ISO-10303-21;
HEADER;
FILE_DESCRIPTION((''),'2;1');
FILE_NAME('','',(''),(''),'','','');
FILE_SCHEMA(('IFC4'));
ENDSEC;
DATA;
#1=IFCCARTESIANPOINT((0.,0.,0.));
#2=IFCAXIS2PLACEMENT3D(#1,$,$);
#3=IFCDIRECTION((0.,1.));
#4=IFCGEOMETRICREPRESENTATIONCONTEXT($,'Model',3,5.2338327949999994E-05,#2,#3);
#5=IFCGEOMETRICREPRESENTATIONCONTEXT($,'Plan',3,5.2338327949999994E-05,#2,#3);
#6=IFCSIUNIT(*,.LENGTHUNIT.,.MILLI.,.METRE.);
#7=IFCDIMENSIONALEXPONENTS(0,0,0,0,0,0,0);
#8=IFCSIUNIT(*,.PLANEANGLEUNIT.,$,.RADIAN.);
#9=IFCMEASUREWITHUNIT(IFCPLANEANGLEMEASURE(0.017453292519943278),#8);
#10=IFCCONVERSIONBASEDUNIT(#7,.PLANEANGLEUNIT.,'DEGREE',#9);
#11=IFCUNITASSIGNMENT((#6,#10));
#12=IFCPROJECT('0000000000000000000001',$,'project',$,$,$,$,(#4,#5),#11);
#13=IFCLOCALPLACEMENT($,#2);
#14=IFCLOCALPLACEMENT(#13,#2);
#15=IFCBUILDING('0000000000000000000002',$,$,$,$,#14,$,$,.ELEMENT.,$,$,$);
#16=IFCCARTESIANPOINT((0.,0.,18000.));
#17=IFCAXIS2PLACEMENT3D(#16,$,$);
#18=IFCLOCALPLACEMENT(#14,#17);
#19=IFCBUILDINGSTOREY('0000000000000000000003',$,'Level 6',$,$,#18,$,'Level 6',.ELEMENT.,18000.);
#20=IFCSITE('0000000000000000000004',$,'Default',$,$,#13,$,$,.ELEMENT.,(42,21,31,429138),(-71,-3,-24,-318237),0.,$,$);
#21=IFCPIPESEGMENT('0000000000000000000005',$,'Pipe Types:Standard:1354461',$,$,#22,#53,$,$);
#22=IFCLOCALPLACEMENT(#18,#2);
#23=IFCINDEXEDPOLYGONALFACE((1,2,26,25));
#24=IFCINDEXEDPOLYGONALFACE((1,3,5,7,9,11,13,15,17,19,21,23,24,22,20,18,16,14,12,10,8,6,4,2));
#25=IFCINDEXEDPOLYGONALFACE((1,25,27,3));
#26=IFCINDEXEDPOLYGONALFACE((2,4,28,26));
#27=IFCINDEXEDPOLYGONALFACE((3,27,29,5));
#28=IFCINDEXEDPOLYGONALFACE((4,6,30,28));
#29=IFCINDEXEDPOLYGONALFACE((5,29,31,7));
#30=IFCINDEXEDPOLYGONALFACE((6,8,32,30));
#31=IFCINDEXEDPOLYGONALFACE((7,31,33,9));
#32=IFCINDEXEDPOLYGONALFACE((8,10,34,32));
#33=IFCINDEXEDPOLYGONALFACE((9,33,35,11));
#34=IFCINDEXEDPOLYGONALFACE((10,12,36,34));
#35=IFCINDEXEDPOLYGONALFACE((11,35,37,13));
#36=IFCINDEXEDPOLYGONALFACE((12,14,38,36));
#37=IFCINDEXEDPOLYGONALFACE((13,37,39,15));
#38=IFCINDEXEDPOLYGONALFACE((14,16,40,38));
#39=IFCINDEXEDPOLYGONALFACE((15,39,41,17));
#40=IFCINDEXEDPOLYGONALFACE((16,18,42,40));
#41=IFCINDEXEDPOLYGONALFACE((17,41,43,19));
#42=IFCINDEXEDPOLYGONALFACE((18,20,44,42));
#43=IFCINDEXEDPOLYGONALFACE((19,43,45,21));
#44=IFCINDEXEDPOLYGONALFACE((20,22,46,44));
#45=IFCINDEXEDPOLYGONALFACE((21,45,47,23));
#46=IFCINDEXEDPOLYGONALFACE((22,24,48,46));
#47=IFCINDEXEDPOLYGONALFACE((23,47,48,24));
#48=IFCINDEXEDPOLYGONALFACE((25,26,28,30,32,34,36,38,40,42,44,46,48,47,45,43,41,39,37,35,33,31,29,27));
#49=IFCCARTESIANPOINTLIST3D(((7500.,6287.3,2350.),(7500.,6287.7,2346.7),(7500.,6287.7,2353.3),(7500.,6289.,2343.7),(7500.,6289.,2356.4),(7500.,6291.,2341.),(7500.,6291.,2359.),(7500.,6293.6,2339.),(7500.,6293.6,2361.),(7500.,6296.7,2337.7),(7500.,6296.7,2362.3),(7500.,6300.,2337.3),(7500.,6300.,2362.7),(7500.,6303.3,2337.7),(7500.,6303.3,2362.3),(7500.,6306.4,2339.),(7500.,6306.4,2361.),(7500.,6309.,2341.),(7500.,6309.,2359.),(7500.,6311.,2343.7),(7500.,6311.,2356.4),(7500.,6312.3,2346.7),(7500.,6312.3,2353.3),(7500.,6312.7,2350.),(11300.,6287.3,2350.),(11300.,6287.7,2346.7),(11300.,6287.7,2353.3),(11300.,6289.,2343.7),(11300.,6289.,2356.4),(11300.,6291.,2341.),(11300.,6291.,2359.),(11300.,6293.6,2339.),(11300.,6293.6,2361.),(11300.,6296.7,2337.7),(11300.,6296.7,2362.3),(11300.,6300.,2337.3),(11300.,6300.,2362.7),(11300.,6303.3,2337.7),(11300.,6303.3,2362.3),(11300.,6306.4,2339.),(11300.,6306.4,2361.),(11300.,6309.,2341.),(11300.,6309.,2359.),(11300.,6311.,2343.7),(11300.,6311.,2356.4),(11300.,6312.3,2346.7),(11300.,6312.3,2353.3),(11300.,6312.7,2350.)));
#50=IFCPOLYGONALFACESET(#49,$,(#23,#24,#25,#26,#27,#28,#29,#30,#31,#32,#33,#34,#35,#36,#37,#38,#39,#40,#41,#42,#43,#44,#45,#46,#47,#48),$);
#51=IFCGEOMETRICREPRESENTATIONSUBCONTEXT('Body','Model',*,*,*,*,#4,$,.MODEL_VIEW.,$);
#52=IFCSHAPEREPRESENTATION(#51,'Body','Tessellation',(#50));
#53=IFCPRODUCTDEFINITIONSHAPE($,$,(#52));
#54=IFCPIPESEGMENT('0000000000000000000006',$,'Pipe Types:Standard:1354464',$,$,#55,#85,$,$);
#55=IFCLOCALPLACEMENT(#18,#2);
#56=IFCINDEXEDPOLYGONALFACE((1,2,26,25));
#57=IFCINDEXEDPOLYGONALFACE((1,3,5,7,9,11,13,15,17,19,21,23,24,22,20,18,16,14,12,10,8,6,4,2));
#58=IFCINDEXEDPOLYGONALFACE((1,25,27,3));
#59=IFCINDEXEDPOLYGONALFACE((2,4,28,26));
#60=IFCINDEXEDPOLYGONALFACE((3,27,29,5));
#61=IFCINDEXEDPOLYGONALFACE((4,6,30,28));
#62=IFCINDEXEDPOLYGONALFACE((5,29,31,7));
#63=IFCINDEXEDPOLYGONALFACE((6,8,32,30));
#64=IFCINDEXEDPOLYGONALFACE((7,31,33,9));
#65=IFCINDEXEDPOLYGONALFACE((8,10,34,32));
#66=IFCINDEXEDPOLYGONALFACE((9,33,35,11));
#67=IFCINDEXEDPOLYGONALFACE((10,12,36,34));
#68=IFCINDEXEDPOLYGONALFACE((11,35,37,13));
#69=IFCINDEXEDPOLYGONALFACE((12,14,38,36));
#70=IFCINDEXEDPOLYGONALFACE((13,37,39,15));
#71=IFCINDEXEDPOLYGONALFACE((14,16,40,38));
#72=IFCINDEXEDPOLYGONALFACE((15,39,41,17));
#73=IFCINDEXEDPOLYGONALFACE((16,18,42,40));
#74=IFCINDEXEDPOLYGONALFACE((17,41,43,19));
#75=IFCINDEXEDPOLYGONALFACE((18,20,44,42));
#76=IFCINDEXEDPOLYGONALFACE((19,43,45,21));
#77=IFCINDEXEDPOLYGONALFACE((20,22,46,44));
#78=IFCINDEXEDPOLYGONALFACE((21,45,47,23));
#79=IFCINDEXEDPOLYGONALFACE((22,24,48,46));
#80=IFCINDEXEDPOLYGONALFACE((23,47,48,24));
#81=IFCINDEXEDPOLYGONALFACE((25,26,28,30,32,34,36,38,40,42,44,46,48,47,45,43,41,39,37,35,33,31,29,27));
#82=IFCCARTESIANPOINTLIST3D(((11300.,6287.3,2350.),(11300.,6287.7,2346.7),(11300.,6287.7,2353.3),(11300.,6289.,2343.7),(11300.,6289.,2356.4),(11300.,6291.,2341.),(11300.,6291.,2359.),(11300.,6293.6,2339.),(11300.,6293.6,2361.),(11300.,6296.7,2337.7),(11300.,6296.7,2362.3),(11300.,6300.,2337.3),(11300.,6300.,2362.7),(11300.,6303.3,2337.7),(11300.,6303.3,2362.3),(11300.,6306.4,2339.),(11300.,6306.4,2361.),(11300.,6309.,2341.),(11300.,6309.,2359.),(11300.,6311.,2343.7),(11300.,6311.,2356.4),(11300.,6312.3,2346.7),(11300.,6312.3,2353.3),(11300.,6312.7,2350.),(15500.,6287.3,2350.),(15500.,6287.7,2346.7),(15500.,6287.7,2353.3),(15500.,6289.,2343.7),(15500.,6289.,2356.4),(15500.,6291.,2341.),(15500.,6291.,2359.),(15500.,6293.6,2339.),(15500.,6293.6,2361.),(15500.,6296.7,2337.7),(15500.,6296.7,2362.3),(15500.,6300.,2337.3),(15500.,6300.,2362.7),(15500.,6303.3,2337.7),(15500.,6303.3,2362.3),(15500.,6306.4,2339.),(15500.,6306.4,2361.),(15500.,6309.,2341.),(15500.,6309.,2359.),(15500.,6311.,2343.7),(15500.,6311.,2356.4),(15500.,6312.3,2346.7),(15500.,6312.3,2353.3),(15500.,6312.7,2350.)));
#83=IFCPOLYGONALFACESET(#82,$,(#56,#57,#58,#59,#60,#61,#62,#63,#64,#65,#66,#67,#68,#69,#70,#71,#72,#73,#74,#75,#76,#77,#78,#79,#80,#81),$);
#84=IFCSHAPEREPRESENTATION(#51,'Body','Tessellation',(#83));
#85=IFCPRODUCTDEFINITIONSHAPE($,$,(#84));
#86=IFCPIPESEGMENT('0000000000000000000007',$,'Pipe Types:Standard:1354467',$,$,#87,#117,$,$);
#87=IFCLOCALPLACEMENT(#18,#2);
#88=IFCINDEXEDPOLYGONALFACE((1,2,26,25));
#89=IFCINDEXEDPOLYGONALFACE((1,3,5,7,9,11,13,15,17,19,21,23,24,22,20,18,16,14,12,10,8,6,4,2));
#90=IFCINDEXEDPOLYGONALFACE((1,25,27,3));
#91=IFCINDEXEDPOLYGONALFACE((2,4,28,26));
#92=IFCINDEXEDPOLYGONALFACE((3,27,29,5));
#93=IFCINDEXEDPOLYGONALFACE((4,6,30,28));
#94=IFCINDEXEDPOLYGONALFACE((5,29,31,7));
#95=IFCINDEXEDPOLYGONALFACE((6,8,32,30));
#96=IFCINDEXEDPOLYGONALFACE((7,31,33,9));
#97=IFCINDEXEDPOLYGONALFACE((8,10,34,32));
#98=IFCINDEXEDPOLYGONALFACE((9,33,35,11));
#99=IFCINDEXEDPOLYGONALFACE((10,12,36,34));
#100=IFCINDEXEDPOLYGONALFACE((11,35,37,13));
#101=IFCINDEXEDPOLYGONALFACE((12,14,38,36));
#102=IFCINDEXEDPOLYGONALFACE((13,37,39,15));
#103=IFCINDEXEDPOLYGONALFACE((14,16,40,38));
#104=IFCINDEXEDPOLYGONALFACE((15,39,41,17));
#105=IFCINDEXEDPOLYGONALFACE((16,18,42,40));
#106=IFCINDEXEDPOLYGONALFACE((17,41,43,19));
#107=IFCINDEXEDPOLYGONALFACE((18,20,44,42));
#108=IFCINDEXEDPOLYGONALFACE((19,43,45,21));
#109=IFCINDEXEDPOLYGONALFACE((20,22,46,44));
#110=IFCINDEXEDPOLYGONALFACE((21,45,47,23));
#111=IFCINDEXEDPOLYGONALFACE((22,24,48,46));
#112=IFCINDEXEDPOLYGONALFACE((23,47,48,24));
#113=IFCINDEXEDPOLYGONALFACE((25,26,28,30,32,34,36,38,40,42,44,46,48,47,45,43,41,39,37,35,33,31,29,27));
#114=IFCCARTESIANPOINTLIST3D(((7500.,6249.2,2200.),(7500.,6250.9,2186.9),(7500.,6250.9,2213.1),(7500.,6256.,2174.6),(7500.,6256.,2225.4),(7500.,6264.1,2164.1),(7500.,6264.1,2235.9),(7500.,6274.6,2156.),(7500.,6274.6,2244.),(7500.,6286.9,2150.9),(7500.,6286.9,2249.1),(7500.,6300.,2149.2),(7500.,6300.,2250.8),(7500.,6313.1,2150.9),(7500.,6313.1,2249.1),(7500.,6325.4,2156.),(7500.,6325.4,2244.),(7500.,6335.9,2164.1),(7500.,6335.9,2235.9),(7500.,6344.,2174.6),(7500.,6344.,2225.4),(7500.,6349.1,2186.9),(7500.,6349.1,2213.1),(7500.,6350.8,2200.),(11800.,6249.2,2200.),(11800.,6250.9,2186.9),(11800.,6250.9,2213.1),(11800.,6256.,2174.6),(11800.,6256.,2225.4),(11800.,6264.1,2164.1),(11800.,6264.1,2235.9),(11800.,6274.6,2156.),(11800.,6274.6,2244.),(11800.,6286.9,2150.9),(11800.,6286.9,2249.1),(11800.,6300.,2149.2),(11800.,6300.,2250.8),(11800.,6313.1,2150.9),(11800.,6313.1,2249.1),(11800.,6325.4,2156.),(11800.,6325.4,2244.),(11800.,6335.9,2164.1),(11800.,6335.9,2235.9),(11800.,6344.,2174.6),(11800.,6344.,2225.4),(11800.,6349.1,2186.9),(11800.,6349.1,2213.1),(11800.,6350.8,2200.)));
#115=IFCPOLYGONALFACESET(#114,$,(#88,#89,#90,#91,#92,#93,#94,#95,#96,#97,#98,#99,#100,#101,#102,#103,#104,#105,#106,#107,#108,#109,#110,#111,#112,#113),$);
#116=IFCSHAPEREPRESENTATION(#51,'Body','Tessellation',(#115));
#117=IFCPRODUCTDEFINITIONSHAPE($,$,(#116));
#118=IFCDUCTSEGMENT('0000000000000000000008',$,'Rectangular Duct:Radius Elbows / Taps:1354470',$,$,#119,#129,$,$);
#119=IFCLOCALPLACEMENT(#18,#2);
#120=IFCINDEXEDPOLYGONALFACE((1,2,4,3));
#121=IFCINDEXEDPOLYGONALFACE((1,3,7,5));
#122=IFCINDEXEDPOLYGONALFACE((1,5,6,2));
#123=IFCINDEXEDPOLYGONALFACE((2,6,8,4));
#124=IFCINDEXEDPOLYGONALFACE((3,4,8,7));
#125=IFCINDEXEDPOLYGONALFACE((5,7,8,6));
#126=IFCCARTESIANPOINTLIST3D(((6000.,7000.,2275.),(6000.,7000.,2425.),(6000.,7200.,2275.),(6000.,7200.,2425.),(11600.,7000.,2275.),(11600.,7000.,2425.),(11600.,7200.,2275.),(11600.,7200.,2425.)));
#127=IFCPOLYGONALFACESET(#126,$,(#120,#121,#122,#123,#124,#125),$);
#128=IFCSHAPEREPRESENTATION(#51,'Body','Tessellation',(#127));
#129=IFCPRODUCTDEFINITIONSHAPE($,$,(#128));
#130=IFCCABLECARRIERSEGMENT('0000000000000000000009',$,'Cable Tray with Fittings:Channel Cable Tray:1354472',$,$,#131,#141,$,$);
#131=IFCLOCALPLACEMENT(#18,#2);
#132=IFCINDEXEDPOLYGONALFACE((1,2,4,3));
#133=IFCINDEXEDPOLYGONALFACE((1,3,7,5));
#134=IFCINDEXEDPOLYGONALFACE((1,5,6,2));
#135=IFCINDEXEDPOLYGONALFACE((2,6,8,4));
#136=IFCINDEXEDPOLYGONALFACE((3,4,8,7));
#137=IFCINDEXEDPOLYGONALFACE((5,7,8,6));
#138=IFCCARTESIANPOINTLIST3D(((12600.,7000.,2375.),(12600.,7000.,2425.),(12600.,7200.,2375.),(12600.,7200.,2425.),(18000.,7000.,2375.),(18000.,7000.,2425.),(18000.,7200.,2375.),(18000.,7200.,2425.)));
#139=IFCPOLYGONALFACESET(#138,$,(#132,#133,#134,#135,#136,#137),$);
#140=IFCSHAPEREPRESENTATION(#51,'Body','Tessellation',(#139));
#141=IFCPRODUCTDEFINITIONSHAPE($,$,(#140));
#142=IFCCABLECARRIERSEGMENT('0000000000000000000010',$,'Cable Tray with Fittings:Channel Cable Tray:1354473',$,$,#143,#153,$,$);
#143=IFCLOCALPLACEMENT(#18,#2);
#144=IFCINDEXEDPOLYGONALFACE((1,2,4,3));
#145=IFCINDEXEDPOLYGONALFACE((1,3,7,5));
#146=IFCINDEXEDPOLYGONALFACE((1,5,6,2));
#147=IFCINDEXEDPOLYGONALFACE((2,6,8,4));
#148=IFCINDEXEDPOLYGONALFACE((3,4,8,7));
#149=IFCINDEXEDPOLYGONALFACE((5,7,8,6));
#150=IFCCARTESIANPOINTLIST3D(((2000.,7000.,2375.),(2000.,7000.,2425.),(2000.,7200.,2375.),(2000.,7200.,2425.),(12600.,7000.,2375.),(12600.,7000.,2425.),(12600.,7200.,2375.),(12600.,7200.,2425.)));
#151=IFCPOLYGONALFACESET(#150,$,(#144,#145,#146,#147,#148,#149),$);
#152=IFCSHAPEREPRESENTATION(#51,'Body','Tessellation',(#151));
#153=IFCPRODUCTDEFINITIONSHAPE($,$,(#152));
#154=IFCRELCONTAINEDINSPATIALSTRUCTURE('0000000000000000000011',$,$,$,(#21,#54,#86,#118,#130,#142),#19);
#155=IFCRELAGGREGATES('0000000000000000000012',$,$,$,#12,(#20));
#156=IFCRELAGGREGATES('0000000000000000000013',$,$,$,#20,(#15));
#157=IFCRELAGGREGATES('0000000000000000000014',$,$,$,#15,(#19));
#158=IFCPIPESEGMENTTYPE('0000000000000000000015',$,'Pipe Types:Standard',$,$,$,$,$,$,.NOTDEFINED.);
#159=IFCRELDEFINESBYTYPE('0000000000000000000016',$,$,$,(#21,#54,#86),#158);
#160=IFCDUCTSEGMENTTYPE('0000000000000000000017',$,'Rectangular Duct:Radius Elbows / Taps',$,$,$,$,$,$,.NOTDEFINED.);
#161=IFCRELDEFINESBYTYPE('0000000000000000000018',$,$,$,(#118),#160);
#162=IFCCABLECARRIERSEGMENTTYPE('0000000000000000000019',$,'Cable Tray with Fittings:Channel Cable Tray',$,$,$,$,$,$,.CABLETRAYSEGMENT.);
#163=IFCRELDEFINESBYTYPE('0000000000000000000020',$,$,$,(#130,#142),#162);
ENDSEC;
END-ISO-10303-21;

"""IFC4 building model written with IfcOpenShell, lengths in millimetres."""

from ifc_helpers import new_model, entity, si_unit, converted_unit, direction, frame, origin, place, context, subcontext, project, spatial, arc, indexed_curve, outline, extrude, type_object, element, save


model = new_model("IFC4")

# Units and contexts
model_context = context("Model", 3, precision=5.2338327949999994e-05, world=origin(), true_north=direction((0.0, 1.0)))
plan_context = context("Plan", 3, precision=5.2338327949999994e-05, world=origin(), true_north=direction((0.0, 1.0)))
body_context = subcontext(model_context, "Body", "Model", "MODEL_VIEW")
ifc_project = project(units=[si_unit("LENGTHUNIT", "METRE", prefix="MILLI"), converted_unit("PLANEANGLEUNIT", "DEGREE", entity("IfcPlaneAngleMeasure", 0.017453292519943278), si_unit("PLANEANGLEUNIT", "RADIAN"), dimensions=[0, 0, 0, 0, 0, 0, 0])], contexts=[model_context, plan_context])

# Site, building, storey
site_placement = place(None, origin())
site = spatial("IfcSite", under=ifc_project, at=site_placement, Name="Default", CompositionType="ELEMENT", RefLatitude=(42, 21, 31, 429138), RefLongitude=(-71, -3, -24, -318237), RefElevation=0.0)
building_placement = place(site_placement, origin())
building = spatial("IfcBuilding", under=site, at=building_placement, CompositionType="ELEMENT")
storey_placement = place(building_placement, frame((0.0, 0.0, 18000.0)))
storey = spatial("IfcBuildingStorey", under=building, at=storey_placement, Name="Level 6", LongName="Level 6", CompositionType="ELEMENT", Elevation=18000.0)

# Pipe segments
pipe_segment_type = type_object("IfcPipeSegmentType", Name="Pipe Types:Standard", PredefinedType="NOTDEFINED")
pipe_segment_1_placement = place(storey_placement, origin())
element("IfcPipeSegment", 1, at=pipe_segment_1_placement, inside=storey, type_object=pipe_segment_type, Name="Pipe Types:Standard:1354461", context=body_context, shape_type="SweptSolid", body=[
    extrude(outline(indexed_curve([(12.7, 0.0), (9.0, 9.0), (0.0, 12.7), (-9.0, 9.0), (-12.7, 0.0), (-9.0, -9.0), (0.0, -12.7), (9.0, -9.0)], segments=[arc(1, 2, 3), arc(3, 4, 5), arc(5, 6, 7), arc(7, 8, 1)], self_intersect=False)), frame((7500.0, 6300.0, 2350.0), z_axis=(1.0, 0.0, 0.0), x_axis=(0.0, 1.0, 0.0)), (0.0, 0.0, 1.0), 3800.0),
])
pipe_segment_2_placement = place(storey_placement, origin())
element("IfcPipeSegment", 2, at=pipe_segment_2_placement, inside=storey, type_object=pipe_segment_type, Name="Pipe Types:Standard:1354464", context=body_context, shape_type="SweptSolid", body=[
    extrude(outline(indexed_curve([(12.7, 0.0), (9.0, 9.0), (0.0, 12.7), (-9.0, 9.0), (-12.7, 0.0), (-9.0, -9.0), (0.0, -12.7), (9.0, -9.0)], segments=[arc(1, 2, 3), arc(3, 4, 5), arc(5, 6, 7), arc(7, 8, 1)], self_intersect=False)), frame((11300.0, 6300.0, 2350.0), z_axis=(1.0, 0.0, 0.0), x_axis=(0.0, -1.0, 0.0)), (0.0, 0.0, 1.0), 4200.0),
])
pipe_segment_3_placement = place(storey_placement, origin())
element("IfcPipeSegment", 3, at=pipe_segment_3_placement, inside=storey, type_object=pipe_segment_type, Name="Pipe Types:Standard:1354467", context=body_context, shape_type="SweptSolid", body=[
    extrude(outline(indexed_curve([(50.8, 0.0), (35.9, 35.9), (0.0, 50.8), (-35.9, 35.9), (-50.8, 0.0), (-35.9, -35.9), (0.0, -50.8), (35.9, -35.9)], segments=[arc(1, 2, 3), arc(3, 4, 5), arc(5, 6, 7), arc(7, 8, 1)], self_intersect=False)), frame((7500.0, 6300.0, 2200.0), z_axis=(1.0, 0.0, 0.0), x_axis=(0.0, 1.0, 0.0)), (0.0, 0.0, 1.0), 4300.0),
])

# Duct segment
duct_segment_type = type_object("IfcDuctSegmentType", Name="Rectangular Duct:Radius Elbows / Taps", PredefinedType="NOTDEFINED")
duct_segment_placement = place(storey_placement, origin())
element("IfcDuctSegment", 4, at=duct_segment_placement, inside=storey, type_object=duct_segment_type, Name="Rectangular Duct:Radius Elbows / Taps:1354470", context=body_context, shape_type="SweptSolid", body=[
    extrude(outline(indexed_curve([(-2800.0, -100.0), (2800.0, -100.0), (2800.0, 100.0), (-2800.0, 100.0), (-2800.0, -100.0)], self_intersect=False)), frame((8800.0, 7100.0, 2275.0), z_axis=(0.0, 0.0, 1.0), x_axis=(-1.0, 0.0, 0.0)), (0.0, 0.0, 1.0), 150.0),
])

# Cable carrier segments
cable_carrier_segment_type = type_object("IfcCableCarrierSegmentType", Name="Cable Tray with Fittings:Channel Cable Tray", PredefinedType="CABLETRAYSEGMENT")
cable_carrier_segment_1_placement = place(storey_placement, origin())
element("IfcCableCarrierSegment", 5, at=cable_carrier_segment_1_placement, inside=storey, type_object=cable_carrier_segment_type, Name="Cable Tray with Fittings:Channel Cable Tray:1354472", context=body_context, shape_type="SweptSolid", body=[
    extrude(outline(indexed_curve([(-2700.0, -100.0), (2700.0, -100.0), (2700.0, 100.0), (-2700.0, 100.0), (-2700.0, -100.0)], self_intersect=False)), frame((15300.0, 7100.0, 2375.0)), (0.0, 0.0, 1.0), 50.0),
])
cable_carrier_segment_2_placement = place(storey_placement, origin())
element("IfcCableCarrierSegment", 6, at=cable_carrier_segment_2_placement, inside=storey, type_object=cable_carrier_segment_type, Name="Cable Tray with Fittings:Channel Cable Tray:1354473", context=body_context, shape_type="SweptSolid", body=[
    extrude(outline(indexed_curve([(-5300.0, -100.0), (5300.0, -100.0), (5300.0, 100.0), (-5300.0, 100.0), (-5300.0, -100.0)], self_intersect=False)), frame((7300.0, 7100.0, 2375.0), z_axis=(0.0, 0.0, 1.0), x_axis=(-1.0, 0.0, 0.0)), (0.0, 0.0, 1.0), 50.0),
])

save(model, "model.ifc")
